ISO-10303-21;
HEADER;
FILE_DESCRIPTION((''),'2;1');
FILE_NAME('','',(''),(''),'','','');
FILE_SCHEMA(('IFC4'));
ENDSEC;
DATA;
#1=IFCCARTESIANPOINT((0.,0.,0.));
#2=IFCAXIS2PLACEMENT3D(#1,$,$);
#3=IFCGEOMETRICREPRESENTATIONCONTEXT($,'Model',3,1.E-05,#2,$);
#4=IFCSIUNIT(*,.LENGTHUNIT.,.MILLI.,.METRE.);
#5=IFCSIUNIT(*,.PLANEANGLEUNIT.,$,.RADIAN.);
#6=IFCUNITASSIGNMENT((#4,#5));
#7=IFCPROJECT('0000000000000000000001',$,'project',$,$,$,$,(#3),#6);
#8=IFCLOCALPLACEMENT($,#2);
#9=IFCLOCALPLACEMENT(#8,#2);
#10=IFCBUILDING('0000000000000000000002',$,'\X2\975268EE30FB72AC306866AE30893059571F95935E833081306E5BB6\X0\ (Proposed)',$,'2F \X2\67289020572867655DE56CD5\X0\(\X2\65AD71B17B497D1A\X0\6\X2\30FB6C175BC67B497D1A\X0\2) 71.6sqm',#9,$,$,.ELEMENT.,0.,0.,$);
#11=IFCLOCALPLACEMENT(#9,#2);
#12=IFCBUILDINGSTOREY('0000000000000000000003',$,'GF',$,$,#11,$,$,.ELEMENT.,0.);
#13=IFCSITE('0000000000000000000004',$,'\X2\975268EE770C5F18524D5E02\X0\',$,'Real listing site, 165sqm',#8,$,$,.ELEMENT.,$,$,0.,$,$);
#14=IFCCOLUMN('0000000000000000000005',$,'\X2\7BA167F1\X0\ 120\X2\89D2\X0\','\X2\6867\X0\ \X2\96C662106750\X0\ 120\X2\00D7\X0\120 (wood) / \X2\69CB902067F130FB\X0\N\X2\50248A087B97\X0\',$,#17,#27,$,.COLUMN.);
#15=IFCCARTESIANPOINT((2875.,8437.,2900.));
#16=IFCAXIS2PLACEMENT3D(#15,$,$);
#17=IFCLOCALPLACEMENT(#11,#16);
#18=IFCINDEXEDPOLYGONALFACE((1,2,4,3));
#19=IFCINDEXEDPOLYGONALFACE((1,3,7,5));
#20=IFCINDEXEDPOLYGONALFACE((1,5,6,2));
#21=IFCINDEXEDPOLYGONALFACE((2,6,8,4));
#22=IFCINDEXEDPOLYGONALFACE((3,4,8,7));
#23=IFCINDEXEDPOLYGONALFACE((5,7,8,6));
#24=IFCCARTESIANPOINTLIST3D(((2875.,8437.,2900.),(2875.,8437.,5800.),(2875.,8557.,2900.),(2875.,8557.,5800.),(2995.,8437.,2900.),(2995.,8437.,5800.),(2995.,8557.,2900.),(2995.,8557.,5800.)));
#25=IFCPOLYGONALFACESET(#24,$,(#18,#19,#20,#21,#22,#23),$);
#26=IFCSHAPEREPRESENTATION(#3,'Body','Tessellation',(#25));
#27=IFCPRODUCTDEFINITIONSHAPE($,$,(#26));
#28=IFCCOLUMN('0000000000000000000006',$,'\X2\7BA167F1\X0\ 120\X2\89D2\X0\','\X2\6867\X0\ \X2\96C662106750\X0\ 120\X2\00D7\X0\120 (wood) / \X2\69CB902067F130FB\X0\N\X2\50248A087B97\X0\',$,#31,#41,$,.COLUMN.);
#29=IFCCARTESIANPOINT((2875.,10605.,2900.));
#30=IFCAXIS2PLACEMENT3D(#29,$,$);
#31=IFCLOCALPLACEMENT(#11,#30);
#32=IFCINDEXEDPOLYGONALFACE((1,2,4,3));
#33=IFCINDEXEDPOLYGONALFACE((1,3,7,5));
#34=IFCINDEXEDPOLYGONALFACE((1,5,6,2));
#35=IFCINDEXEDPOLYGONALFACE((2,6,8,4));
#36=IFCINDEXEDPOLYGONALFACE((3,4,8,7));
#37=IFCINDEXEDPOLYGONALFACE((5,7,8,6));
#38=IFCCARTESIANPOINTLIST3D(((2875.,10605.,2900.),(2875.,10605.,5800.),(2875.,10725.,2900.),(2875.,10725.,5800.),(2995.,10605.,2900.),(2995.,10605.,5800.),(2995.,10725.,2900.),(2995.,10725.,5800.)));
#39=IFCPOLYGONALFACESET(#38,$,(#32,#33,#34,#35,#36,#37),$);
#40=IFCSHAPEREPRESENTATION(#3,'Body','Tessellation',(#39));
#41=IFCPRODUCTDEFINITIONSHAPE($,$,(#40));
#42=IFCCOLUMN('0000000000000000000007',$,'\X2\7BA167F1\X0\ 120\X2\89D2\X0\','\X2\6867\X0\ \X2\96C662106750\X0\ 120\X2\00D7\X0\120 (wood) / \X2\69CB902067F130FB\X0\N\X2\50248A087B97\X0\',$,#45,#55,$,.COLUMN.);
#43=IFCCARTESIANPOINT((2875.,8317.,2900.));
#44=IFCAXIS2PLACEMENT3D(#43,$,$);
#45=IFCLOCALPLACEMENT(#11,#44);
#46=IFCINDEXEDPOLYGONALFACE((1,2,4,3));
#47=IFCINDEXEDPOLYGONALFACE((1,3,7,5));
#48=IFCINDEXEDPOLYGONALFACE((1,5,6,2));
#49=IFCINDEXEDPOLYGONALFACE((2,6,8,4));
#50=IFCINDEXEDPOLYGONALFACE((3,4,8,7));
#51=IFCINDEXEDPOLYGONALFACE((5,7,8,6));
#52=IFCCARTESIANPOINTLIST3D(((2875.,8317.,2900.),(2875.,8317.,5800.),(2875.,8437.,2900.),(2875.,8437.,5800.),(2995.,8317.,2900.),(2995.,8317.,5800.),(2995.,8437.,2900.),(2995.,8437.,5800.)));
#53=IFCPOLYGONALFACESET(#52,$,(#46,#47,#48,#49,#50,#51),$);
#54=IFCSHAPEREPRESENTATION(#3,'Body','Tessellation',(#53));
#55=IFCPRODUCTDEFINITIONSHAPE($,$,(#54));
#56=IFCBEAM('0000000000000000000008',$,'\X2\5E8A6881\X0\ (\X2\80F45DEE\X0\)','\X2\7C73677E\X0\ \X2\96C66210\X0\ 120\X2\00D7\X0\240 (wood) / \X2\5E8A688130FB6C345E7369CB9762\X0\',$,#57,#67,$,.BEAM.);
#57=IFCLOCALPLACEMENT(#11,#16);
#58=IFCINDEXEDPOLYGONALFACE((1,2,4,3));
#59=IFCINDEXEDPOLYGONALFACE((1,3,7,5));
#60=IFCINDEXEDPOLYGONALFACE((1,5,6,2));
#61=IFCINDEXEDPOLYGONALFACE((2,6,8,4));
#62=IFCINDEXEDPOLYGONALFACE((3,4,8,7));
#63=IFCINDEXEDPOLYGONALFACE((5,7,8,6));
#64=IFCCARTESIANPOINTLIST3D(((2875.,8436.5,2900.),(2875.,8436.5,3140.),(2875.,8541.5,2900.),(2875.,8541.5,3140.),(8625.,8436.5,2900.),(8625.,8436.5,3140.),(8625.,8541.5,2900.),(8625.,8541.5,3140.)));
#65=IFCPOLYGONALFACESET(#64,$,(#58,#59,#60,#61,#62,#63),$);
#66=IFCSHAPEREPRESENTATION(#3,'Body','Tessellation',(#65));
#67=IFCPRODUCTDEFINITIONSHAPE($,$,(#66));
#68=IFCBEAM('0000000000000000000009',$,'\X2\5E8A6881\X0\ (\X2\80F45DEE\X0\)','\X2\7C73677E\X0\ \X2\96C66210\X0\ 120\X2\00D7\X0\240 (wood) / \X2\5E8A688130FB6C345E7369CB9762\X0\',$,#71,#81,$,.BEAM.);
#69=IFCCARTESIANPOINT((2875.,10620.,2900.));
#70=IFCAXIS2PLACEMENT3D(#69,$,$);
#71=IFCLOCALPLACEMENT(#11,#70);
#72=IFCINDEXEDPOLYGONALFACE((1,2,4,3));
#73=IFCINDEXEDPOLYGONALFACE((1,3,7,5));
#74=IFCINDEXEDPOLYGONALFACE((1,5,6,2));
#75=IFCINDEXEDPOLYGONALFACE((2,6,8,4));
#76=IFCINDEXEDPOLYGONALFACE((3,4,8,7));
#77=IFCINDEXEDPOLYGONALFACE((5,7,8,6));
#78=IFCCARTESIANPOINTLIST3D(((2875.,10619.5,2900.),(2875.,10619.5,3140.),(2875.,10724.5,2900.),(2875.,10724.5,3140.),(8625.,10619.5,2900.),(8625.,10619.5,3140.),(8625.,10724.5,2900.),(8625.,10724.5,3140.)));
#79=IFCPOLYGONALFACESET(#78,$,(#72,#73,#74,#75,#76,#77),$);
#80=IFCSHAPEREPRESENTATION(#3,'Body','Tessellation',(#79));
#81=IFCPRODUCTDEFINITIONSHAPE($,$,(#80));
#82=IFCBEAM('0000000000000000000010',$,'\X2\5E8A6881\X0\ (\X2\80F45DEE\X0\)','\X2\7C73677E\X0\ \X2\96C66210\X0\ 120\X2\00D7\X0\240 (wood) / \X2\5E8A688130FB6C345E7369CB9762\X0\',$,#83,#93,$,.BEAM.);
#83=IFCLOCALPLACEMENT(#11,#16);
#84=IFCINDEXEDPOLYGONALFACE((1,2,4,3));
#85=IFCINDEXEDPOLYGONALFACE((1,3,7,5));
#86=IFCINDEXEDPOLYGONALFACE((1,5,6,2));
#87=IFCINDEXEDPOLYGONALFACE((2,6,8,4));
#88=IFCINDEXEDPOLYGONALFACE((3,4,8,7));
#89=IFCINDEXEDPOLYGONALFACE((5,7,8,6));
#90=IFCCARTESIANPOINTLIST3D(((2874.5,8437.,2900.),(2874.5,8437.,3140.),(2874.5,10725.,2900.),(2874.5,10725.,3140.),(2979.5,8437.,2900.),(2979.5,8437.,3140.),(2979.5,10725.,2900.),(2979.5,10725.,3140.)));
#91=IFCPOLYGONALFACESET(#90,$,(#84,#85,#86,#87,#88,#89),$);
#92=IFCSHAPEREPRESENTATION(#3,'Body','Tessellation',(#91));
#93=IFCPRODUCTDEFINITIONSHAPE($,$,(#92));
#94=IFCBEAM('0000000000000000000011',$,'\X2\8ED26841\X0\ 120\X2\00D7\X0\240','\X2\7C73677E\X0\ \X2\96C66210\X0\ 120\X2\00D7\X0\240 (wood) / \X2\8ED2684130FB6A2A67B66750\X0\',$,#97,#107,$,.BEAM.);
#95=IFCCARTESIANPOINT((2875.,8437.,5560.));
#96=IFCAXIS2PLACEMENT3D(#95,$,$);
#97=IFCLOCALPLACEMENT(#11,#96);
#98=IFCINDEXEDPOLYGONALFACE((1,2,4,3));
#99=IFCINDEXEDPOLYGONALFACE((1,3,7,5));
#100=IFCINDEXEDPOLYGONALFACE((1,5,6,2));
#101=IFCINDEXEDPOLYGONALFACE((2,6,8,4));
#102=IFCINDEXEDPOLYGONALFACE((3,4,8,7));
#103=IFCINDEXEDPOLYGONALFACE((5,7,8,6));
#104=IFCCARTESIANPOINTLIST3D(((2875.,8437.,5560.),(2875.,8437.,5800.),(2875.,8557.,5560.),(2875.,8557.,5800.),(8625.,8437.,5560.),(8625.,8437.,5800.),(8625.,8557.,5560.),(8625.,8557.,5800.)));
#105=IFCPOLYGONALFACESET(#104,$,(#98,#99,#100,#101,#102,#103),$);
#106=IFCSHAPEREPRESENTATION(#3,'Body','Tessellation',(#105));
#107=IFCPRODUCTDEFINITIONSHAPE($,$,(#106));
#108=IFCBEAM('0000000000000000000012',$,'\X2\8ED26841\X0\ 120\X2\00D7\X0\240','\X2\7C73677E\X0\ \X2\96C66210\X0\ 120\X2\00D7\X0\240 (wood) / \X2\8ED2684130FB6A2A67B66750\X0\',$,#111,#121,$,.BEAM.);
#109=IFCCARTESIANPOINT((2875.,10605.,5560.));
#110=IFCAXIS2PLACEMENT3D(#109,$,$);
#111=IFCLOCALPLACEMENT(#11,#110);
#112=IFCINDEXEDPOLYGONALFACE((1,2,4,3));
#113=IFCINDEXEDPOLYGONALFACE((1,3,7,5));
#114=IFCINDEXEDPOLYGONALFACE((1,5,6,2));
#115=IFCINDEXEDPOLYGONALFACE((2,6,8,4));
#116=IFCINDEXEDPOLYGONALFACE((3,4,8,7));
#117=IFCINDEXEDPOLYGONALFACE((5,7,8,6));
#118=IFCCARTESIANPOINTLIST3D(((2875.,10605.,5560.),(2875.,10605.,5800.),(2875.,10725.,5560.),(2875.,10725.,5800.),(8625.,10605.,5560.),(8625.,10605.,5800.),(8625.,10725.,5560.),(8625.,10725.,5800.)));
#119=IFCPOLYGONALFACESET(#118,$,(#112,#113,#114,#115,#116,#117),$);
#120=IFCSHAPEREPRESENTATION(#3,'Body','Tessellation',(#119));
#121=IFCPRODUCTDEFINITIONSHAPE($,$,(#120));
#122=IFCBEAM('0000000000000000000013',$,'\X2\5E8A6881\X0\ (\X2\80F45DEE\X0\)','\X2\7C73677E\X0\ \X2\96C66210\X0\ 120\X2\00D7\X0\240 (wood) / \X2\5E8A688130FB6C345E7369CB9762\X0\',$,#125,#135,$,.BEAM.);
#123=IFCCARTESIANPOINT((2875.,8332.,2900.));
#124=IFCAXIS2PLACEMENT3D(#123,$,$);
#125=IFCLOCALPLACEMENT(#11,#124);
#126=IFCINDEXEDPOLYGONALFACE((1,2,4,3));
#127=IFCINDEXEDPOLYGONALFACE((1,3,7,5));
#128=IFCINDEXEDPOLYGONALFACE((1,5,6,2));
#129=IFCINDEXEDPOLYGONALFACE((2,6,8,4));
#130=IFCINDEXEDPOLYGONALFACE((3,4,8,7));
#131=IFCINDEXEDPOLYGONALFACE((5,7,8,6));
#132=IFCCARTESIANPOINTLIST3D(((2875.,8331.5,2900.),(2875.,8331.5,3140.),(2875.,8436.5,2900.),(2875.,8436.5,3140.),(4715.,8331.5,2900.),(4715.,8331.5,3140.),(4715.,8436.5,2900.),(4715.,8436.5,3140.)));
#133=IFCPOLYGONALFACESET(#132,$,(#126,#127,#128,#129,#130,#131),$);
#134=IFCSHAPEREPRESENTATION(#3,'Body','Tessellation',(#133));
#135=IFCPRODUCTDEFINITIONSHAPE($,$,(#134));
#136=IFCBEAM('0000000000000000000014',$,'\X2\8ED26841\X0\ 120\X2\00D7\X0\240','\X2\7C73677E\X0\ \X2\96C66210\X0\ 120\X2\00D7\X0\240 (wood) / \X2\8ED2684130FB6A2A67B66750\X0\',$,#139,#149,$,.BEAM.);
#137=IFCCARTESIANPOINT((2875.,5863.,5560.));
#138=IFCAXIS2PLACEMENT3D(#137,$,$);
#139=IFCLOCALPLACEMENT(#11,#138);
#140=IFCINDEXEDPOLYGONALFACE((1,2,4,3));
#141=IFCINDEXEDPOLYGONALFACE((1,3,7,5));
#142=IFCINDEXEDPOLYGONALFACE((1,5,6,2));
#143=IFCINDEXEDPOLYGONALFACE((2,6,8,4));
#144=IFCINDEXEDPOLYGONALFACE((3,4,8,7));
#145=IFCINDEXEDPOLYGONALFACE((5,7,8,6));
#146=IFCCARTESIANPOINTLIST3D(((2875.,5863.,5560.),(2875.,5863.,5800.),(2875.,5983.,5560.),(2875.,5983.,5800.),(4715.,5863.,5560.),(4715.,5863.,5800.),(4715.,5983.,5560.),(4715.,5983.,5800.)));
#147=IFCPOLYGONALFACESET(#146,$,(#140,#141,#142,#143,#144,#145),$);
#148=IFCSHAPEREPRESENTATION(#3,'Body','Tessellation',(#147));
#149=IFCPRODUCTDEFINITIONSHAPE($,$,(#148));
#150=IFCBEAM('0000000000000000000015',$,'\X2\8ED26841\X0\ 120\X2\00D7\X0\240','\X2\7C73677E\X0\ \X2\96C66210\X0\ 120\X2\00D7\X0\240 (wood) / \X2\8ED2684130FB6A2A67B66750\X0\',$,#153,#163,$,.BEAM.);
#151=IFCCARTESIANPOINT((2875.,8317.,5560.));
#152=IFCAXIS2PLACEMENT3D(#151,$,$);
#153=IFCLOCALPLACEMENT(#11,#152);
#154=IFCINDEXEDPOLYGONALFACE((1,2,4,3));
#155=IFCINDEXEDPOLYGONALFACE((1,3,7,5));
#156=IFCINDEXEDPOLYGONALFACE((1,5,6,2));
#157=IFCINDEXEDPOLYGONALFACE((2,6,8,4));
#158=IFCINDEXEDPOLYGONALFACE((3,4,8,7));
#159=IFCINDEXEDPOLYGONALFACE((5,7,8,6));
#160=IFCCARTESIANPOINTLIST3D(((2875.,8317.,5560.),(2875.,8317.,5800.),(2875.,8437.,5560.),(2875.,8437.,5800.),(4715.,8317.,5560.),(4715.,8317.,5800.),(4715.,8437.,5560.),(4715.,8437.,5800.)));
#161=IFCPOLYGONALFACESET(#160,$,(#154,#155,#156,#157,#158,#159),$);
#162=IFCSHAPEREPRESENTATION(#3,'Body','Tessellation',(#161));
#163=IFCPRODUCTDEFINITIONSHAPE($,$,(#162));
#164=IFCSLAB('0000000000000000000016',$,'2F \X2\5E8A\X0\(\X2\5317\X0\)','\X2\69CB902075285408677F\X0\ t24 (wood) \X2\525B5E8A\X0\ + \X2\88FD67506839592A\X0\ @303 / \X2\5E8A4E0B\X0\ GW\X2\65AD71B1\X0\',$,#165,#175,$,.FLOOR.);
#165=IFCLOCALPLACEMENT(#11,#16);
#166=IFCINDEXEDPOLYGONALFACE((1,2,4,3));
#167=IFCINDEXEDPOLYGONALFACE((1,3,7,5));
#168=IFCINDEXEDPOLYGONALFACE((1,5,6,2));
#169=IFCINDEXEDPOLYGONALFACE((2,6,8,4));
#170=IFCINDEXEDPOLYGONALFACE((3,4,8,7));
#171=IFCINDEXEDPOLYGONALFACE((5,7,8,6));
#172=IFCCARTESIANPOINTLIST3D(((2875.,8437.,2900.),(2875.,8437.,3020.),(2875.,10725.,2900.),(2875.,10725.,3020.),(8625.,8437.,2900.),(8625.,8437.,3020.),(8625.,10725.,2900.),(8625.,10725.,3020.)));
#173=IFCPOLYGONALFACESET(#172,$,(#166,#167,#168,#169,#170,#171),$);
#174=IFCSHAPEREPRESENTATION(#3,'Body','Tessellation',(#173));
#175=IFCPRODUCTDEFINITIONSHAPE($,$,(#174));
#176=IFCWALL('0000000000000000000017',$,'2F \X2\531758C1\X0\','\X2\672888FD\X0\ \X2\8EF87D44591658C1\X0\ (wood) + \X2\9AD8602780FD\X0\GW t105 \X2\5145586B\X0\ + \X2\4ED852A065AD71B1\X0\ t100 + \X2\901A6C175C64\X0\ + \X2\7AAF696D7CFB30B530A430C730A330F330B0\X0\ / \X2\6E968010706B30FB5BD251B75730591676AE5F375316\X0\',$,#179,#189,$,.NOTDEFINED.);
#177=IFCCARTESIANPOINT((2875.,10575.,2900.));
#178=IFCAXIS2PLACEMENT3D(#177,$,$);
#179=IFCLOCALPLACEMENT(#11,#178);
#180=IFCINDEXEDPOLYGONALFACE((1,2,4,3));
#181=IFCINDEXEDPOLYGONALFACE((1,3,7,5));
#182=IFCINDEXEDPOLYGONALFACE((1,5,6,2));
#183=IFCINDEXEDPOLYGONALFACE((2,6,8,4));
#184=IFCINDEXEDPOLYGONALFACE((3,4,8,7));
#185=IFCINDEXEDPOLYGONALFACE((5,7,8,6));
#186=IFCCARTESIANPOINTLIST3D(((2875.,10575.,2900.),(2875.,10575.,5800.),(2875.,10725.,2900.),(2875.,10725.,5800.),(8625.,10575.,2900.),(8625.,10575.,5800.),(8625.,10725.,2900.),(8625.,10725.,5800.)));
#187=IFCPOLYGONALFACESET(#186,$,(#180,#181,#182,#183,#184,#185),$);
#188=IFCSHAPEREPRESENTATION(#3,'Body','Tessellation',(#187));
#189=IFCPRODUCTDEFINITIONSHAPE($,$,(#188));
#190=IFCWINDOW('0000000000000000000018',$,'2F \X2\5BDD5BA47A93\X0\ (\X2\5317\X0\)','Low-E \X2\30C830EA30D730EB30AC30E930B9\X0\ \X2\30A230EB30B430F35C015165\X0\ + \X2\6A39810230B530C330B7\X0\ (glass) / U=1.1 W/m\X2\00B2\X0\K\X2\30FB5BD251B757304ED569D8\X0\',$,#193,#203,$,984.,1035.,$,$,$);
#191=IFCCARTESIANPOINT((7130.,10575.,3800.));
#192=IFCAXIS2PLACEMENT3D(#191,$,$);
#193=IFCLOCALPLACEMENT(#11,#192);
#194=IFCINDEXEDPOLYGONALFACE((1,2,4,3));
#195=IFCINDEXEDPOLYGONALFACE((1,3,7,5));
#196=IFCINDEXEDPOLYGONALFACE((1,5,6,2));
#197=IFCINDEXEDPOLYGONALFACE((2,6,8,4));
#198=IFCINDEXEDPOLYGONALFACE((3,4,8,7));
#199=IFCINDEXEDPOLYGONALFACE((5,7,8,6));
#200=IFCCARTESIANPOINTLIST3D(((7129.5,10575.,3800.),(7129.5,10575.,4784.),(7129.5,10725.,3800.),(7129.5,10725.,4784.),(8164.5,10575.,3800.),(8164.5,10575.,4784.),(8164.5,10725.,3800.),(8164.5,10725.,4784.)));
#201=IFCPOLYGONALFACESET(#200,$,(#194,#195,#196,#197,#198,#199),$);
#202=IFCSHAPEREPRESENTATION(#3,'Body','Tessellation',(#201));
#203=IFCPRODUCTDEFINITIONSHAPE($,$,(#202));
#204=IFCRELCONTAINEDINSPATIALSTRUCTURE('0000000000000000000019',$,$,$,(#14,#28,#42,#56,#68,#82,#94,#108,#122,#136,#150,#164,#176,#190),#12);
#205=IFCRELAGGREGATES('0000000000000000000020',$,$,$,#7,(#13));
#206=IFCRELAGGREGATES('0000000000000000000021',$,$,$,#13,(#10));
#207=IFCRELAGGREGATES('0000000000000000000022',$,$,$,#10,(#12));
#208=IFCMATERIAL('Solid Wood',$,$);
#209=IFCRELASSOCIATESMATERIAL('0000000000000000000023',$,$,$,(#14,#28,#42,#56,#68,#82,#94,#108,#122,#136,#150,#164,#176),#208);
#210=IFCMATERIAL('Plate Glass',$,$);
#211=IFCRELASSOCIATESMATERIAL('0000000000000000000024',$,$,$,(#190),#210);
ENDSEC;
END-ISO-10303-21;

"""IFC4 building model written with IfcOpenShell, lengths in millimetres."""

from ifc_helpers import new_model, si_unit, frame, frame_2d, origin, place, context, project, spatial, rectangle, extrude, material, element, fill, save


model = new_model("IFC4")

# Units and contexts
model_context = context("Model", 3, precision=1e-05, world=origin())
ifc_project = project(units=[si_unit("LENGTHUNIT", "METRE", prefix="MILLI"), si_unit("PLANEANGLEUNIT", "RADIAN")], contexts=[model_context])

# Site, building, storey
site_placement = place(None, origin())
site = spatial("IfcSite", under=ifc_project, at=site_placement, Name="青森県弘前市", ObjectType="Real listing site, 165sqm", CompositionType="ELEMENT", RefElevation=0.0)
building_placement = place(site_placement, origin())
building = spatial("IfcBuilding", under=site, at=building_placement, Name="青森・犬と暮らす土間広めの家 (Proposed)", ObjectType="2F 木造在来工法(断熱等級6・気密等級2) 71.6sqm", CompositionType="ELEMENT", ElevationOfRefHeight=0.0, ElevationOfTerrain=0.0)
storey_placement = place(building_placement, origin())
storey = spatial("IfcBuildingStorey", under=building, at=storey_placement, Name="GF", CompositionType="ELEMENT", Elevation=0.0)

# Columns
ifc_material_1 = material(Name="Solid Wood")
column_1_placement = place(storey_placement, frame((2875.0, 8437.0, 2900.0)))
element("IfcColumn", 1, at=column_1_placement, inside=storey, material=ifc_material_1, Name="管柱 120角", Description="桧 集成材 120×120 (wood) / 構造柱・N値計算", PredefinedType="COLUMN", context=model_context, shape_type="SweptSolid", body=[
    extrude(rectangle(XDim=120.0, YDim=120.0, at=frame_2d((60.0, 60.0))), frame((2875.0, 8437.0, 2900.0)), (0.0, 0.0, 1.0), 2900.0),
])
column_2_placement = place(storey_placement, frame((2875.0, 10605.0, 2900.0)))
element("IfcColumn", 2, at=column_2_placement, inside=storey, material=ifc_material_1, Name="管柱 120角", Description="桧 集成材 120×120 (wood) / 構造柱・N値計算", PredefinedType="COLUMN", context=model_context, shape_type="SweptSolid", body=[
    extrude(rectangle(XDim=120.0, YDim=120.0, at=frame_2d((60.0, 60.0))), frame((2875.0, 10605.0, 2900.0)), (0.0, 0.0, 1.0), 2900.0),
])
column_3_placement = place(storey_placement, frame((2875.0, 8317.0, 2900.0)))
element("IfcColumn", 3, at=column_3_placement, inside=storey, material=ifc_material_1, Name="管柱 120角", Description="桧 集成材 120×120 (wood) / 構造柱・N値計算", PredefinedType="COLUMN", context=model_context, shape_type="SweptSolid", body=[
    extrude(rectangle(XDim=120.0, YDim=120.0, at=frame_2d((60.0, 60.0))), frame((2875.0, 8317.0, 2900.0)), (0.0, 0.0, 1.0), 2900.0),
])

# Beams
beam_1_placement = place(storey_placement, frame((2875.0, 8437.0, 2900.0)))
element("IfcBeam", 4, at=beam_1_placement, inside=storey, material=ifc_material_1, Name="床梁 (胴差)", Description="米松 集成 120×240 (wood) / 床梁・水平構面", PredefinedType="BEAM", context=model_context, shape_type="SweptSolid", body=[
    extrude(rectangle(XDim=5750.0, YDim=105.0, at=frame_2d((2875.0, 52.0))), frame((2875.0, 8437.0, 2900.0)), (0.0, 0.0, 1.0), 240.0),
])
beam_2_placement = place(storey_placement, frame((2875.0, 10620.0, 2900.0)))
element("IfcBeam", 5, at=beam_2_placement, inside=storey, material=ifc_material_1, Name="床梁 (胴差)", Description="米松 集成 120×240 (wood) / 床梁・水平構面", PredefinedType="BEAM", context=model_context, shape_type="SweptSolid", body=[
    extrude(rectangle(XDim=5750.0, YDim=105.0, at=frame_2d((2875.0, 52.0))), frame((2875.0, 10620.0, 2900.0)), (0.0, 0.0, 1.0), 240.0),
])
beam_3_placement = place(storey_placement, frame((2875.0, 8437.0, 2900.0)))
element("IfcBeam", 6, at=beam_3_placement, inside=storey, material=ifc_material_1, Name="床梁 (胴差)", Description="米松 集成 120×240 (wood) / 床梁・水平構面", PredefinedType="BEAM", context=model_context, shape_type="SweptSolid", body=[
    extrude(rectangle(XDim=105.0, YDim=2288.0, at=frame_2d((52.0, 1144.0))), frame((2875.0, 8437.0, 2900.0)), (0.0, 0.0, 1.0), 240.0),
])
beam_4_placement = place(storey_placement, frame((2875.0, 8437.0, 5560.0)))
element("IfcBeam", 7, at=beam_4_placement, inside=storey, material=ifc_material_1, Name="軒桁 120×240", Description="米松 集成 120×240 (wood) / 軒桁・横架材", PredefinedType="BEAM", context=model_context, shape_type="SweptSolid", body=[
    extrude(rectangle(XDim=5750.0, YDim=120.0, at=frame_2d((2875.0, 60.0))), frame((2875.0, 8437.0, 5560.0)), (0.0, 0.0, 1.0), 240.0),
])
beam_5_placement = place(storey_placement, frame((2875.0, 10605.0, 5560.0)))
element("IfcBeam", 8, at=beam_5_placement, inside=storey, material=ifc_material_1, Name="軒桁 120×240", Description="米松 集成 120×240 (wood) / 軒桁・横架材", PredefinedType="BEAM", context=model_context, shape_type="SweptSolid", body=[
    extrude(rectangle(XDim=5750.0, YDim=120.0, at=frame_2d((2875.0, 60.0))), frame((2875.0, 10605.0, 5560.0)), (0.0, 0.0, 1.0), 240.0),
])
beam_6_placement = place(storey_placement, frame((2875.0, 8332.0, 2900.0)))
element("IfcBeam", 9, at=beam_6_placement, inside=storey, material=ifc_material_1, Name="床梁 (胴差)", Description="米松 集成 120×240 (wood) / 床梁・水平構面", PredefinedType="BEAM", context=model_context, shape_type="SweptSolid", body=[
    extrude(rectangle(XDim=1840.0, YDim=105.0, at=frame_2d((920.0, 52.0))), frame((2875.0, 8332.0, 2900.0)), (0.0, 0.0, 1.0), 240.0),
])
beam_7_placement = place(storey_placement, frame((2875.0, 5863.0, 5560.0)))
element("IfcBeam", 10, at=beam_7_placement, inside=storey, material=ifc_material_1, Name="軒桁 120×240", Description="米松 集成 120×240 (wood) / 軒桁・横架材", PredefinedType="BEAM", context=model_context, shape_type="SweptSolid", body=[
    extrude(rectangle(XDim=1840.0, YDim=120.0, at=frame_2d((920.0, 60.0))), frame((2875.0, 5863.0, 5560.0)), (0.0, 0.0, 1.0), 240.0),
])
beam_8_placement = place(storey_placement, frame((2875.0, 8317.0, 5560.0)))
element("IfcBeam", 11, at=beam_8_placement, inside=storey, material=ifc_material_1, Name="軒桁 120×240", Description="米松 集成 120×240 (wood) / 軒桁・横架材", PredefinedType="BEAM", context=model_context, shape_type="SweptSolid", body=[
    extrude(rectangle(XDim=1840.0, YDim=120.0, at=frame_2d((920.0, 60.0))), frame((2875.0, 8317.0, 5560.0)), (0.0, 0.0, 1.0), 240.0),
])

# Slab
slab_placement = place(storey_placement, frame((2875.0, 8437.0, 2900.0)))
element("IfcSlab", 12, at=slab_placement, inside=storey, material=ifc_material_1, Name="2F 床(北)", Description="構造用合板 t24 (wood) 剛床 + 製材根太 @303 / 床下 GW断熱", PredefinedType="FLOOR", context=model_context, shape_type="SweptSolid", body=[
    extrude(rectangle(XDim=5750.0, YDim=2288.0, at=frame_2d((2875.0, 1144.0))), frame((2875.0, 8437.0, 2900.0)), (0.0, 0.0, 1.0), 120.0),
])

# Wall, opening, window
wall_placement = place(storey_placement, frame((2875.0, 10575.0, 2900.0)))
wall = element("IfcWall", 13, at=wall_placement, inside=storey, material=ifc_material_1, Name="2F 北壁", Description="木製 軸組外壁 (wood) + 高性能GW t105 充填 + 付加断熱 t100 + 通気層 + 窯業系サイディング / 準耐火・寒冷地外皮強化", PredefinedType="NOTDEFINED", context=model_context, shape_type="SweptSolid", body=[
    extrude(rectangle(XDim=5750.0, YDim=150.0, at=frame_2d((2875.0, 75.0))), frame((2875.0, 10575.0, 2900.0)), (0.0, 0.0, 1.0), 2900.0),
])
opening_placement = place(storey_placement, frame((7130.0, 10575.0, 3800.0)))
opening = element("IfcOpeningElement", 14, at=opening_placement, cuts=wall, PredefinedType="NOTDEFINED", context=model_context, shape_type="SweptSolid", body=[
    extrude(rectangle(XDim=1035.0, YDim=150.0, at=frame_2d((517.0, 75.0))), frame((7130.0, 10575.0, 3800.0)), (0.0, 0.0, 1.0), 984.0),
])
ifc_material_2 = material(Name="Plate Glass")
window_placement = place(storey_placement, frame((7130.0, 10575.0, 3800.0)))
window = element("IfcWindow", 15, at=window_placement, inside=storey, material=ifc_material_2, Name="2F 寝室窓 (北)", Description="Low-E トリプルガラス アルゴン封入 + 樹脂サッシ (glass) / U=1.1 W/m²K・寒冷地仕様", OverallHeight=984.0, OverallWidth=1035.0, context=model_context, shape_type="SweptSolid", body=[
    extrude(rectangle(XDim=1035.0, YDim=150.0, at=frame_2d((517.0, 75.0))), frame((7130.0, 10575.0, 3800.0)), (0.0, 0.0, 1.0), 984.0),
])
fill(opening, window)

save(model, "model.ifc")
